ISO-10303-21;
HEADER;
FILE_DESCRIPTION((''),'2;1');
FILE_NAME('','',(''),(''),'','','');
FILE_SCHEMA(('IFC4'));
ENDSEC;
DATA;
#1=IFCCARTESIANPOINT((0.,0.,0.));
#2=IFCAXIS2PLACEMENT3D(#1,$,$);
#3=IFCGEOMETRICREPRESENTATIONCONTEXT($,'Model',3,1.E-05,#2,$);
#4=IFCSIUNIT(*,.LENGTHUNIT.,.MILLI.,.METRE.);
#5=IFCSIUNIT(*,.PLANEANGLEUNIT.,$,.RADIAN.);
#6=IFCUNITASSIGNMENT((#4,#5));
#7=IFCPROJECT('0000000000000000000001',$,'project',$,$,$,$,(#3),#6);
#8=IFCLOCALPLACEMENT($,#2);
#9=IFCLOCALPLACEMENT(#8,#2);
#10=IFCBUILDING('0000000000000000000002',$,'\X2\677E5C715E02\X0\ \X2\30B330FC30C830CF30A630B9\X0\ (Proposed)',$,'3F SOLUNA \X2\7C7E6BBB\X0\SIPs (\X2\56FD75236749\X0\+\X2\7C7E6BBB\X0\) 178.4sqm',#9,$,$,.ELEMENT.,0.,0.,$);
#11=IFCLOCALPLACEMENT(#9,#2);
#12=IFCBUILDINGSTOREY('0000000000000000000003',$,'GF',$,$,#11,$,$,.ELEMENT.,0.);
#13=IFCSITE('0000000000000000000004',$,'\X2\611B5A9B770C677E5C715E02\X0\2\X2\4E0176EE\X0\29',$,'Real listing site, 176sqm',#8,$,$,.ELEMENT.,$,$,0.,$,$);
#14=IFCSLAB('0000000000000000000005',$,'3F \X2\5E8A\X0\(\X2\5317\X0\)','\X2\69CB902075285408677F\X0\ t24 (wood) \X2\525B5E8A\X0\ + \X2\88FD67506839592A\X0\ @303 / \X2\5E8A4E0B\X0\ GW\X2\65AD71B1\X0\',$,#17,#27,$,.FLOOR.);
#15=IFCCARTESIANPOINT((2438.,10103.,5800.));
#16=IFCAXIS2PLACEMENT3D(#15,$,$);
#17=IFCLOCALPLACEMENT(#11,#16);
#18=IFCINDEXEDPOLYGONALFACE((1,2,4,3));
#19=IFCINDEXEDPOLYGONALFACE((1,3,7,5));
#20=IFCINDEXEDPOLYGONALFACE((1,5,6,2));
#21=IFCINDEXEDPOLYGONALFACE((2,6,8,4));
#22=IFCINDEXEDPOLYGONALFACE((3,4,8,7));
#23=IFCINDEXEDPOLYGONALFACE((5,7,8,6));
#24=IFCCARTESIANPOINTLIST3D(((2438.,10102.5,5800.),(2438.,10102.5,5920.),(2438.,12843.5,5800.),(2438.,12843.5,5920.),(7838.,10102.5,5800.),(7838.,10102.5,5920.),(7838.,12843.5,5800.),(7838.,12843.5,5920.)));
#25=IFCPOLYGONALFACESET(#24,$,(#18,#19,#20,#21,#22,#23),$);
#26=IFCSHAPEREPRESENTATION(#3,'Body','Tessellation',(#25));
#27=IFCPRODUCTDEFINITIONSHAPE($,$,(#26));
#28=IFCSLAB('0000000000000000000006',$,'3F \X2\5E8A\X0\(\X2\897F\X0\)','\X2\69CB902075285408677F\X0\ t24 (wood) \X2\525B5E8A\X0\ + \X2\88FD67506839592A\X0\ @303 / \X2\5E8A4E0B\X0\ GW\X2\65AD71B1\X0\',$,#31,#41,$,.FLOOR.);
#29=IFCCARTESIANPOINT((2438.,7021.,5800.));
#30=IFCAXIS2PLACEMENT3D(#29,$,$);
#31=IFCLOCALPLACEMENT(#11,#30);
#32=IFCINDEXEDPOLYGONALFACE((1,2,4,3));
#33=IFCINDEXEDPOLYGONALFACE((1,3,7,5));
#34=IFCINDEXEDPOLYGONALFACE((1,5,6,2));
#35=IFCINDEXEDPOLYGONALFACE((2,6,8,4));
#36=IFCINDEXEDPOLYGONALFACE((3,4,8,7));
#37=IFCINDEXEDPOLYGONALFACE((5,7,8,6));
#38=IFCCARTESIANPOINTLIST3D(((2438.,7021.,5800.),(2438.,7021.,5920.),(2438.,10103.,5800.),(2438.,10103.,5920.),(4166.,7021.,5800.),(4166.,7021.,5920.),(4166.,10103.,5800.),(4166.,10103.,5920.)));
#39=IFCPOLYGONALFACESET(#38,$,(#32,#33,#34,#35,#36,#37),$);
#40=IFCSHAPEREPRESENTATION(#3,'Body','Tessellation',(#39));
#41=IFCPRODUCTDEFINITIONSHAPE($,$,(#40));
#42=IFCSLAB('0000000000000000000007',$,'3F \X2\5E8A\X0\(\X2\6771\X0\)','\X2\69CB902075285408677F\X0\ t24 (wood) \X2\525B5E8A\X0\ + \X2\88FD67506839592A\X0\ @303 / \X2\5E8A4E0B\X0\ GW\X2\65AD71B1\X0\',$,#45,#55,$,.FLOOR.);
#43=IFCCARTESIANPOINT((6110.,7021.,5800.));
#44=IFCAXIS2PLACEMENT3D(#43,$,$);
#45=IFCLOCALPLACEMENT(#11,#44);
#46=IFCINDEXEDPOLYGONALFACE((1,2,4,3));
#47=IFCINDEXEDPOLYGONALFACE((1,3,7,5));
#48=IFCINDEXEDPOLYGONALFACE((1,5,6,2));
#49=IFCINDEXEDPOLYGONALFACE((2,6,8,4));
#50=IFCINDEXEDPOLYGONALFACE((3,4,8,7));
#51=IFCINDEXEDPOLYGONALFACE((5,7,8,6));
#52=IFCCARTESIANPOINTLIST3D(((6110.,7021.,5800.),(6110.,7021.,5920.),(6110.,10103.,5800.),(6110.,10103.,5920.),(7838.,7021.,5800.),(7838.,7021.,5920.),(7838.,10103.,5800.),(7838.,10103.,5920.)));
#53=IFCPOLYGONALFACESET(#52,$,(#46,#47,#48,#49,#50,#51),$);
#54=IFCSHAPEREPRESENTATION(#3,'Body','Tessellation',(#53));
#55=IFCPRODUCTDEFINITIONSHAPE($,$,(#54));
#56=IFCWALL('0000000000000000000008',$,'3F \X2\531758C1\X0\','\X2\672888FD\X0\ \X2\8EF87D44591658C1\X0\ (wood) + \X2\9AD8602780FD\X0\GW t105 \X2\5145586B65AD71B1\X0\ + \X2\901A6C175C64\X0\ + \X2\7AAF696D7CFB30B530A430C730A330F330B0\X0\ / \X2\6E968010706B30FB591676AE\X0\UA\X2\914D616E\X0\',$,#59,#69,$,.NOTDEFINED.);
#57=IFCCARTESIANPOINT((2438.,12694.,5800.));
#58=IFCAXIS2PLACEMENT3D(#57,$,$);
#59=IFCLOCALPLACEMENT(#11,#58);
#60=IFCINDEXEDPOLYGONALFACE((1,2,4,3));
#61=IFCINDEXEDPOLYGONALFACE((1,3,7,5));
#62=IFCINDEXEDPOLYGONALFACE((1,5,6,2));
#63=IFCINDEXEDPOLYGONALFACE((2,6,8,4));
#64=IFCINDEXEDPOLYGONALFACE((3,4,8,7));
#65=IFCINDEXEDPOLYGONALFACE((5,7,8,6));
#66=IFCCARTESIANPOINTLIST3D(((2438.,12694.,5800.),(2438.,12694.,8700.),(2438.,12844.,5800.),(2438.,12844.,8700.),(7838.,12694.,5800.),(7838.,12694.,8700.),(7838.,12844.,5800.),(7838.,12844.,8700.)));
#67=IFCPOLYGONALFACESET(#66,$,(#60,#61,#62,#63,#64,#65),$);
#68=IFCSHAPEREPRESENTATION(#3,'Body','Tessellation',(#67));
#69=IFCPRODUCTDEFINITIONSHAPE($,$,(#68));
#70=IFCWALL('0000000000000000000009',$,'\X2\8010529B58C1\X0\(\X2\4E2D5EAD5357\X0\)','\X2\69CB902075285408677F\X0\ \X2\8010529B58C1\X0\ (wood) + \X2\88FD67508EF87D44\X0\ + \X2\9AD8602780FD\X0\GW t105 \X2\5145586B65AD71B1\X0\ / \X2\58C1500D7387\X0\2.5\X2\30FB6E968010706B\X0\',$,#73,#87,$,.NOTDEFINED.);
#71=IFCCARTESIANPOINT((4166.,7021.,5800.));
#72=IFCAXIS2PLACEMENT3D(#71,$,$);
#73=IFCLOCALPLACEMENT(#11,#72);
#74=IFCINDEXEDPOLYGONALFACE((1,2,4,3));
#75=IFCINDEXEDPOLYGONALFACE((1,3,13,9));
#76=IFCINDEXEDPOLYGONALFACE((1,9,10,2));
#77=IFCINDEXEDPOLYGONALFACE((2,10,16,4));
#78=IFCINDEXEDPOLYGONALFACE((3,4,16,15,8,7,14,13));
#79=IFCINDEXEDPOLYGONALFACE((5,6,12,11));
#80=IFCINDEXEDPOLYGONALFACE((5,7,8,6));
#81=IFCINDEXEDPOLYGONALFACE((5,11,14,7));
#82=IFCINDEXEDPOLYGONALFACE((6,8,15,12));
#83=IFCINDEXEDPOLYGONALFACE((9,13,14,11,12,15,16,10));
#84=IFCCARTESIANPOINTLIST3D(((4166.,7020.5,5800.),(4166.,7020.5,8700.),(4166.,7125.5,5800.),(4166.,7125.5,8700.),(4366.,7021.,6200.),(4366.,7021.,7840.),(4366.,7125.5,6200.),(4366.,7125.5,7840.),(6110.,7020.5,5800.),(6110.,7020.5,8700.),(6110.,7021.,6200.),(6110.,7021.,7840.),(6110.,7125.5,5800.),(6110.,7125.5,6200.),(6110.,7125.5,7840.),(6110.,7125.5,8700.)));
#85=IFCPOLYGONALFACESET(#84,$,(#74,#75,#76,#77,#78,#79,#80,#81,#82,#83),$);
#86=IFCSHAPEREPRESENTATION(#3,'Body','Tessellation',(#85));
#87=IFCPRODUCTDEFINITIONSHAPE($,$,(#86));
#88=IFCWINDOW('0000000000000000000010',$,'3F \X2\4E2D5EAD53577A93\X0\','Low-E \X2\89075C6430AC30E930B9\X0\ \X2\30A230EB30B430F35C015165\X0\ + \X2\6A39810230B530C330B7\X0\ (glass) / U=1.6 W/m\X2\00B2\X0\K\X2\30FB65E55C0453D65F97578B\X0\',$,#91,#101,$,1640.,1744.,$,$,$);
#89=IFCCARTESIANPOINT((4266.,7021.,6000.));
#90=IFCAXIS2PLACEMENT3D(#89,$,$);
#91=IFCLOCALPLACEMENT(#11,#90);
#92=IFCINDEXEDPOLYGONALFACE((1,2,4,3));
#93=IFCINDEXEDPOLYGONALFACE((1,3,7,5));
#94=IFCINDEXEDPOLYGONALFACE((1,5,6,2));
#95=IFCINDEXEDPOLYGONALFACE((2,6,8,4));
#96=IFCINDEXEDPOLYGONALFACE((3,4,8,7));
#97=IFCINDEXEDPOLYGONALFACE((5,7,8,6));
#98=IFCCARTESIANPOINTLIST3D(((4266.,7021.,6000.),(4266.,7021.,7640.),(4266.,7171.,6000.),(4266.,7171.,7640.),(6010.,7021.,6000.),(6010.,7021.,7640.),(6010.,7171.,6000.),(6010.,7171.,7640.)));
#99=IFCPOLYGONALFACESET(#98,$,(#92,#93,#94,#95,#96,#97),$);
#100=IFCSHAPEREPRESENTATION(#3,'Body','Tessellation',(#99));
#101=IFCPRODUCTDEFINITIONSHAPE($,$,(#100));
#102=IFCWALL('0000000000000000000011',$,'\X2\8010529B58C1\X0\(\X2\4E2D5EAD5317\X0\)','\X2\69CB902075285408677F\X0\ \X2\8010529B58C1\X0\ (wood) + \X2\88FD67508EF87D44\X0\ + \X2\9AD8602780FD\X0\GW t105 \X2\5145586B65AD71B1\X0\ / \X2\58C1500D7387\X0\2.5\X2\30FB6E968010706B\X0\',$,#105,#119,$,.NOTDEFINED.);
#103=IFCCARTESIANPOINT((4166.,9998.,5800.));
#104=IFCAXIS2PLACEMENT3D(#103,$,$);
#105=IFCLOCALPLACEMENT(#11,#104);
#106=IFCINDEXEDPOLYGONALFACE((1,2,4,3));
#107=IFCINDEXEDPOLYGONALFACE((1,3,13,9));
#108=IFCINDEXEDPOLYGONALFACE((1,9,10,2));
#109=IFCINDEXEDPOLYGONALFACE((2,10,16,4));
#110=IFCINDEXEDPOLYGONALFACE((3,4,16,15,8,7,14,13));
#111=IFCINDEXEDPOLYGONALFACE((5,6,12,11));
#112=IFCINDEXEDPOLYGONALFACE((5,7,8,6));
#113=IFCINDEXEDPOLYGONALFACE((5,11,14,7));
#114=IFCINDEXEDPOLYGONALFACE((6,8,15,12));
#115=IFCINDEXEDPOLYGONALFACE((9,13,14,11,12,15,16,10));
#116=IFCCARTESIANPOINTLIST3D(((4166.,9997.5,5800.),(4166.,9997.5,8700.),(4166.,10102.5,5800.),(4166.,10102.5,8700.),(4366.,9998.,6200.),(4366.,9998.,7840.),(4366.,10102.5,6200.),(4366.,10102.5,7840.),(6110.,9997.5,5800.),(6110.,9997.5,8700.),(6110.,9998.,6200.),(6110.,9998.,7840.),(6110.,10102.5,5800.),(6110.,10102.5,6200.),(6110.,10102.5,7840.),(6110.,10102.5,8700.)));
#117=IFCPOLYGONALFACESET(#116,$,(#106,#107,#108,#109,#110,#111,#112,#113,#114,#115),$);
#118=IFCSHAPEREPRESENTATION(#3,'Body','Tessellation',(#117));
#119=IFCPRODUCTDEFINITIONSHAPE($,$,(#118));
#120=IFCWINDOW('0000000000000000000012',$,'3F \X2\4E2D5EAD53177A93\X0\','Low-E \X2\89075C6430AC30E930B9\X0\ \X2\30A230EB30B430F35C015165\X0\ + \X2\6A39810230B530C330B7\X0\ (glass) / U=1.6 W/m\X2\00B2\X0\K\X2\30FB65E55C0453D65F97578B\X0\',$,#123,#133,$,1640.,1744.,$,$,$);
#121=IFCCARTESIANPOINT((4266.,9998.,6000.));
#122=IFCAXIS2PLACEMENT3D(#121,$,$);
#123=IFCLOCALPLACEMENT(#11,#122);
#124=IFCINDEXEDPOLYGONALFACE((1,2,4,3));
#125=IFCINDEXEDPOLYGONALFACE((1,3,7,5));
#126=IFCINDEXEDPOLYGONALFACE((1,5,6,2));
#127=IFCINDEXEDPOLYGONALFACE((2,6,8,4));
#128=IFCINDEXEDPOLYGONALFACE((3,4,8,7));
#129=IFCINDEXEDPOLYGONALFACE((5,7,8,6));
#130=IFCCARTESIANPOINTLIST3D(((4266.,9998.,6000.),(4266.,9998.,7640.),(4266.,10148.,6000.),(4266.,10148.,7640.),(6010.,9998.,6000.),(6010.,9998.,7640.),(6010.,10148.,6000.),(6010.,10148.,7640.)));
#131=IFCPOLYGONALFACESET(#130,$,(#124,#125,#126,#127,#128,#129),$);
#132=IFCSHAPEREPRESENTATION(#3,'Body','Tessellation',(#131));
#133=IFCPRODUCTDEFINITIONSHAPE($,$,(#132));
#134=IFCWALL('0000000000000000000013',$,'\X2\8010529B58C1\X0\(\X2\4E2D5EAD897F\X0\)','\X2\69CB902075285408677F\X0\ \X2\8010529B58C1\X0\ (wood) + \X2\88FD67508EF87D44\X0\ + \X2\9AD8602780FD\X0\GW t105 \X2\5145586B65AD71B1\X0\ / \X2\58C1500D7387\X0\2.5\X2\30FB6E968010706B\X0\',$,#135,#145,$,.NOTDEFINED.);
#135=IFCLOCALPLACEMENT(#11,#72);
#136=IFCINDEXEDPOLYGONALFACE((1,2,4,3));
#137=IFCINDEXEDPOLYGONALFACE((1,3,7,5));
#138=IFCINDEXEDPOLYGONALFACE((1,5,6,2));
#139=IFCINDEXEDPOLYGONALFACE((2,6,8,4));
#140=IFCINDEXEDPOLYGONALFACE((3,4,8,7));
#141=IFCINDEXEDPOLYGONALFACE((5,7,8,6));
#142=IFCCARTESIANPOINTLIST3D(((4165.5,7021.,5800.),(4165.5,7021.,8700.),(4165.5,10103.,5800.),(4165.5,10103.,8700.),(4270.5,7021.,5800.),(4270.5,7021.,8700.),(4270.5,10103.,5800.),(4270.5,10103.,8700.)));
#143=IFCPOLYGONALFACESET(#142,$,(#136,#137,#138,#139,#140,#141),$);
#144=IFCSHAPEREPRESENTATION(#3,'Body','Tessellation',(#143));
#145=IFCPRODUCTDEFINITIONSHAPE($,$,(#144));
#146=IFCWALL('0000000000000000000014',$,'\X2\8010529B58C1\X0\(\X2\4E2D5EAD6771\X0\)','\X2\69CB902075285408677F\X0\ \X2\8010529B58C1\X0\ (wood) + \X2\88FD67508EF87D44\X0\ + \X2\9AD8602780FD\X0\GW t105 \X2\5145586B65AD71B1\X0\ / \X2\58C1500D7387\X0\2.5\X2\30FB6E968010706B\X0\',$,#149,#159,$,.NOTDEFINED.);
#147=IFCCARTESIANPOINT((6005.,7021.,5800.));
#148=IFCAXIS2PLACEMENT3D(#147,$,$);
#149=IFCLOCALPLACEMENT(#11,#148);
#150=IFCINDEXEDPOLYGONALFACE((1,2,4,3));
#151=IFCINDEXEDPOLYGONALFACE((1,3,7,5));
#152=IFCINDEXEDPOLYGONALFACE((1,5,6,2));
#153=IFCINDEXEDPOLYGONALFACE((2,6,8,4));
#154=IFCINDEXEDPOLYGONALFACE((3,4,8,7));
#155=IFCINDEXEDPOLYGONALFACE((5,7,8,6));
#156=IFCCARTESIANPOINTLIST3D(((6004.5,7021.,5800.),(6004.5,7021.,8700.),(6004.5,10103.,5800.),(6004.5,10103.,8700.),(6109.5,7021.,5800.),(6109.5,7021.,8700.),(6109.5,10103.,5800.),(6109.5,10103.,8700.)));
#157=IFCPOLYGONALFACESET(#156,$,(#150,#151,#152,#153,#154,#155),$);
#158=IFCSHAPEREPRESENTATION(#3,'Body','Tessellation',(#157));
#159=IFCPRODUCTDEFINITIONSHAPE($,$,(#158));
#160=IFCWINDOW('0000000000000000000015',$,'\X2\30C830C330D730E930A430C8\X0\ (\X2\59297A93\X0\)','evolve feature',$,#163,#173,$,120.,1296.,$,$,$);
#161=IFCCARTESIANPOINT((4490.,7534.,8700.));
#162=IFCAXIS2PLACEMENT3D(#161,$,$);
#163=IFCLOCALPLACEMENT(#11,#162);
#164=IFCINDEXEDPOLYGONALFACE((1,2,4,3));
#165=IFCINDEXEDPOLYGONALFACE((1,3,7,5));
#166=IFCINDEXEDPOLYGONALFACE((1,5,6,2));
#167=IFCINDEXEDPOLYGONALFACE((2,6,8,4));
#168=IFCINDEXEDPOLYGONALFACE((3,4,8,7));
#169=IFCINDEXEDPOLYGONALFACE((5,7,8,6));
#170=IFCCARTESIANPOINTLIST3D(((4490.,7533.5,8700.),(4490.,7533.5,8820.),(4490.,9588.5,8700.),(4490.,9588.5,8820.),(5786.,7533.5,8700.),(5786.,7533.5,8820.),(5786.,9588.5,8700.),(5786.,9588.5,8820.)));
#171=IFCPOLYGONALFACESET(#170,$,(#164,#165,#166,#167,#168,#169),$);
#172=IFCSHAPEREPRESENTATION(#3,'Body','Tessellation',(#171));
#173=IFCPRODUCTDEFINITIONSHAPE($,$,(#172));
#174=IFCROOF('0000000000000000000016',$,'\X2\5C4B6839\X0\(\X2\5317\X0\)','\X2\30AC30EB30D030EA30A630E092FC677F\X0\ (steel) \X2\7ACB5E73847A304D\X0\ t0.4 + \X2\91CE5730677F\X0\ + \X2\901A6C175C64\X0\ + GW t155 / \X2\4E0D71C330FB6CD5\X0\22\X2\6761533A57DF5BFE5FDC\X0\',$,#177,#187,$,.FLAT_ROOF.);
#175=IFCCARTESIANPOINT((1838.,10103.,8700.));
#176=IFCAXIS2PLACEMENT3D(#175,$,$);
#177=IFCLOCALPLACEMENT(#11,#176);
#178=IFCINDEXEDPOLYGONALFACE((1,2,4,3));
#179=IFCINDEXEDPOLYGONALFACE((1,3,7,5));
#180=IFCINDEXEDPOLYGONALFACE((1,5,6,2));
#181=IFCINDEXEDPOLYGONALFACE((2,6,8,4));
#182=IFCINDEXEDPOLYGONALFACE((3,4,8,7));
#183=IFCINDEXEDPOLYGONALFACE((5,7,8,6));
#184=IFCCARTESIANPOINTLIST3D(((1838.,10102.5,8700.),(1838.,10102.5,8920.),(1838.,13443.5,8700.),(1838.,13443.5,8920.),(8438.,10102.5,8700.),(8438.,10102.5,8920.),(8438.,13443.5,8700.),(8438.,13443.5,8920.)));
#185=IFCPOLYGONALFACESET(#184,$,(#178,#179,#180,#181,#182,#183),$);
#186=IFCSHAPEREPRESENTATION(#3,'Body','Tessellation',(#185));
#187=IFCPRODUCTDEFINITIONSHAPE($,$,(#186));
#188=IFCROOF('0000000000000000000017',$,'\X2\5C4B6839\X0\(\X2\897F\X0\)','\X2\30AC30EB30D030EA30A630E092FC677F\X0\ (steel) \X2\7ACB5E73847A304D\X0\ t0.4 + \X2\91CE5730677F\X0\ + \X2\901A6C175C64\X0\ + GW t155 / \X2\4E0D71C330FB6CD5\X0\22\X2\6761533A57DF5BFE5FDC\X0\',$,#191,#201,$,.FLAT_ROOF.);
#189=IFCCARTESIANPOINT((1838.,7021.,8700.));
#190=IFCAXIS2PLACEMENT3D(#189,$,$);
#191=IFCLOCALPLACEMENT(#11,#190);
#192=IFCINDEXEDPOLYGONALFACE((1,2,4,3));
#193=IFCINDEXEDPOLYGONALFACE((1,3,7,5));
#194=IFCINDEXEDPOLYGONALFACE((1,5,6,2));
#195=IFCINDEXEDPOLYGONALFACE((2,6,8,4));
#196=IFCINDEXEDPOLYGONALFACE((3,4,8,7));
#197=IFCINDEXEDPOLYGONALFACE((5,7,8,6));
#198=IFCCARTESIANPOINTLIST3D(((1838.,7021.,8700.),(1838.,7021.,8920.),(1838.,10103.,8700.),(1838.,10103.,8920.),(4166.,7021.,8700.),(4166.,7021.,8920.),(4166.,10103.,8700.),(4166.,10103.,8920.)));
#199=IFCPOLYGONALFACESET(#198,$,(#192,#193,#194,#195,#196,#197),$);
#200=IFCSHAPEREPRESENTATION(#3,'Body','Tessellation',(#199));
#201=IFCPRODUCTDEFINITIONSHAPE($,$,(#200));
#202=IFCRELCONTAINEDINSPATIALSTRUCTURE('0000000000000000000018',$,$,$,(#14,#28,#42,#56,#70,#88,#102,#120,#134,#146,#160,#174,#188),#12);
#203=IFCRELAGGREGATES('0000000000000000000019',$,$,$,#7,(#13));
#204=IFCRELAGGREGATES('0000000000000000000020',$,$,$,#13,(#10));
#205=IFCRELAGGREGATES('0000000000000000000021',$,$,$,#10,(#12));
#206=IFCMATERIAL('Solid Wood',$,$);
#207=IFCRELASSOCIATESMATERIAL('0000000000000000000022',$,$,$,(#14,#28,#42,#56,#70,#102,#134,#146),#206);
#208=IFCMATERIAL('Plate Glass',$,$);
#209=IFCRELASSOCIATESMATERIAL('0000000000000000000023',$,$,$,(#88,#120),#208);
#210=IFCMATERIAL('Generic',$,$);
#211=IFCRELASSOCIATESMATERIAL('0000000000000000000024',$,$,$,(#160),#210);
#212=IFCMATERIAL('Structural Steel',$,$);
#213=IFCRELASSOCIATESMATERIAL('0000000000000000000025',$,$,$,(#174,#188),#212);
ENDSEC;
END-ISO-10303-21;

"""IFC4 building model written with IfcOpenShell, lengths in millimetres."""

from ifc_helpers import new_model, si_unit, frame, frame_2d, origin, place, context, project, spatial, rectangle, extrude, material, element, fill, save


model = new_model("IFC4")

# Units and contexts
model_context = context("Model", 3, precision=1e-05, world=origin())
ifc_project = project(units=[si_unit("LENGTHUNIT", "METRE", prefix="MILLI"), si_unit("PLANEANGLEUNIT", "RADIAN")], contexts=[model_context])

# Site, building, storey
site_placement = place(None, origin())
site = spatial("IfcSite", under=ifc_project, at=site_placement, Name="愛媛県松山市2丁目29", ObjectType="Real listing site, 176sqm", CompositionType="ELEMENT", RefElevation=0.0)
building_placement = place(site_placement, origin())
building = spatial("IfcBuilding", under=site, at=building_placement, Name="松山市 コートハウス (Proposed)", ObjectType="3F SOLUNA 籾殻SIPs (国産杉+籾殻) 178.4sqm", CompositionType="ELEMENT", ElevationOfRefHeight=0.0, ElevationOfTerrain=0.0)
storey_placement = place(building_placement, origin())
storey = spatial("IfcBuildingStorey", under=building, at=storey_placement, Name="GF", CompositionType="ELEMENT", Elevation=0.0)

# Slabs
ifc_material_1 = material(Name="Solid Wood")
slab_1_placement = place(storey_placement, frame((2438.0, 10103.0, 5800.0)))
element("IfcSlab", 1, at=slab_1_placement, inside=storey, material=ifc_material_1, Name="3F 床(北)", Description="構造用合板 t24 (wood) 剛床 + 製材根太 @303 / 床下 GW断熱", PredefinedType="FLOOR", context=model_context, shape_type="SweptSolid", body=[
    extrude(rectangle(XDim=5400.0, YDim=2741.0, at=frame_2d((2700.0, 1370.0))), frame((2438.0, 10103.0, 5800.0)), (0.0, 0.0, 1.0), 120.0),
])
slab_2_placement = place(storey_placement, frame((2438.0, 7021.0, 5800.0)))
element("IfcSlab", 2, at=slab_2_placement, inside=storey, material=ifc_material_1, Name="3F 床(西)", Description="構造用合板 t24 (wood) 剛床 + 製材根太 @303 / 床下 GW断熱", PredefinedType="FLOOR", context=model_context, shape_type="SweptSolid", body=[
    extrude(rectangle(XDim=1728.0, YDim=3082.0, at=frame_2d((864.0, 1541.0))), frame((2438.0, 7021.0, 5800.0)), (0.0, 0.0, 1.0), 120.0),
])
slab_3_placement = place(storey_placement, frame((6110.0, 7021.0, 5800.0)))
element("IfcSlab", 3, at=slab_3_placement, inside=storey, material=ifc_material_1, Name="3F 床(東)", Description="構造用合板 t24 (wood) 剛床 + 製材根太 @303 / 床下 GW断熱", PredefinedType="FLOOR", context=model_context, shape_type="SweptSolid", body=[
    extrude(rectangle(XDim=1728.0, YDim=3082.0, at=frame_2d((864.0, 1541.0))), frame((6110.0, 7021.0, 5800.0)), (0.0, 0.0, 1.0), 120.0),
])

# Wall
wall_1_placement = place(storey_placement, frame((2438.0, 12694.0, 5800.0)))
element("IfcWall", 4, at=wall_1_placement, inside=storey, material=ifc_material_1, Name="3F 北壁", Description="木製 軸組外壁 (wood) + 高性能GW t105 充填断熱 + 通気層 + 窯業系サイディング / 準耐火・外皮UA配慮", PredefinedType="NOTDEFINED", context=model_context, shape_type="SweptSolid", body=[
    extrude(rectangle(XDim=5400.0, YDim=150.0, at=frame_2d((2700.0, 75.0))), frame((2438.0, 12694.0, 5800.0)), (0.0, 0.0, 1.0), 2900.0),
])

# Walls, openings, windows
wall_2_placement = place(storey_placement, frame((4166.0, 7021.0, 5800.0)))
wall_2 = element("IfcWall", 5, at=wall_2_placement, inside=storey, material=ifc_material_1, Name="耐力壁(中庭南)", Description="構造用合板 耐力壁 (wood) + 製材軸組 + 高性能GW t105 充填断熱 / 壁倍率2.5・準耐火", PredefinedType="NOTDEFINED", context=model_context, shape_type="SweptSolid", body=[
    extrude(rectangle(XDim=1944.0, YDim=105.0, at=frame_2d((972.0, 52.0))), frame((4166.0, 7021.0, 5800.0)), (0.0, 0.0, 1.0), 2900.0),
])
opening_1_placement = place(storey_placement, frame((4266.0, 7021.0, 6000.0)))
opening_1 = element("IfcOpeningElement", 6, at=opening_1_placement, cuts=wall_2, PredefinedType="NOTDEFINED", context=model_context, shape_type="SweptSolid", body=[
    extrude(rectangle(XDim=1744.0, YDim=150.0, at=frame_2d((872.0, 75.0))), frame((4266.0, 7021.0, 6000.0)), (0.0, 0.0, 1.0), 1640.0),
])
ifc_material_2 = material(Name="Plate Glass")
window_1_placement = place(storey_placement, frame((4266.0, 7021.0, 6000.0)))
window_1 = element("IfcWindow", 7, at=window_1_placement, inside=storey, material=ifc_material_2, Name="3F 中庭南窓", Description="Low-E 複層ガラス アルゴン封入 + 樹脂サッシ (glass) / U=1.6 W/m²K・日射取得型", OverallHeight=1640.0, OverallWidth=1744.0, context=model_context, shape_type="SweptSolid", body=[
    extrude(rectangle(XDim=1744.0, YDim=150.0, at=frame_2d((872.0, 75.0))), frame((4266.0, 7021.0, 6000.0)), (0.0, 0.0, 1.0), 1640.0),
])
fill(opening_1, window_1)
wall_3_placement = place(storey_placement, frame((4166.0, 9998.0, 5800.0)))
wall_3 = element("IfcWall", 8, at=wall_3_placement, inside=storey, material=ifc_material_1, Name="耐力壁(中庭北)", Description="構造用合板 耐力壁 (wood) + 製材軸組 + 高性能GW t105 充填断熱 / 壁倍率2.5・準耐火", PredefinedType="NOTDEFINED", context=model_context, shape_type="SweptSolid", body=[
    extrude(rectangle(XDim=1944.0, YDim=105.0, at=frame_2d((972.0, 52.0))), frame((4166.0, 9998.0, 5800.0)), (0.0, 0.0, 1.0), 2900.0),
])
opening_2_placement = place(storey_placement, frame((4266.0, 9998.0, 6000.0)))
opening_2 = element("IfcOpeningElement", 9, at=opening_2_placement, cuts=wall_3, PredefinedType="NOTDEFINED", context=model_context, shape_type="SweptSolid", body=[
    extrude(rectangle(XDim=1744.0, YDim=150.0, at=frame_2d((872.0, 75.0))), frame((4266.0, 9998.0, 6000.0)), (0.0, 0.0, 1.0), 1640.0),
])
window_2_placement = place(storey_placement, frame((4266.0, 9998.0, 6000.0)))
window_2 = element("IfcWindow", 10, at=window_2_placement, inside=storey, material=ifc_material_2, Name="3F 中庭北窓", Description="Low-E 複層ガラス アルゴン封入 + 樹脂サッシ (glass) / U=1.6 W/m²K・日射取得型", OverallHeight=1640.0, OverallWidth=1744.0, context=model_context, shape_type="SweptSolid", body=[
    extrude(rectangle(XDim=1744.0, YDim=150.0, at=frame_2d((872.0, 75.0))), frame((4266.0, 9998.0, 6000.0)), (0.0, 0.0, 1.0), 1640.0),
])
fill(opening_2, window_2)

# Walls
wall_4_placement = place(storey_placement, frame((4166.0, 7021.0, 5800.0)))
element("IfcWall", 11, at=wall_4_placement, inside=storey, material=ifc_material_1, Name="耐力壁(中庭西)", Description="構造用合板 耐力壁 (wood) + 製材軸組 + 高性能GW t105 充填断熱 / 壁倍率2.5・準耐火", PredefinedType="NOTDEFINED", context=model_context, shape_type="SweptSolid", body=[
    extrude(rectangle(XDim=105.0, YDim=3082.0, at=frame_2d((52.0, 1541.0))), frame((4166.0, 7021.0, 5800.0)), (0.0, 0.0, 1.0), 2900.0),
])
wall_5_placement = place(storey_placement, frame((6005.0, 7021.0, 5800.0)))
element("IfcWall", 12, at=wall_5_placement, inside=storey, material=ifc_material_1, Name="耐力壁(中庭東)", Description="構造用合板 耐力壁 (wood) + 製材軸組 + 高性能GW t105 充填断熱 / 壁倍率2.5・準耐火", PredefinedType="NOTDEFINED", context=model_context, shape_type="SweptSolid", body=[
    extrude(rectangle(XDim=105.0, YDim=3082.0, at=frame_2d((52.0, 1541.0))), frame((6005.0, 7021.0, 5800.0)), (0.0, 0.0, 1.0), 2900.0),
])

# Window
ifc_material_3 = material(Name="Generic")
window_3_placement = place(storey_placement, frame((4490.0, 7534.0, 8700.0)))
element("IfcWindow", 13, at=window_3_placement, inside=storey, material=ifc_material_3, Name="トップライト (天窓)", Description="evolve feature", OverallHeight=120.0, OverallWidth=1296.0, context=model_context, shape_type="SweptSolid", body=[
    extrude(rectangle(XDim=1296.0, YDim=2055.0, at=frame_2d((648.0, 1027.0))), frame((4490.0, 7534.0, 8700.0)), (0.0, 0.0, 1.0), 120.0),
])

# Roofs
ifc_material_4 = material(Name="Structural Steel")
for number, where, name in (
    (14, (1838.0, 10103.0, 8700.0), "屋根(北)"),
):
    element("IfcRoof", number, at=place(storey_placement, frame(where)), inside=storey, material=ifc_material_4, Name=name, Description="ガルバリウム鋼板 (steel) 立平葺き t0.4 + 野地板 + 通気層 + GW t155 / 不燃・法22条区域対応", PredefinedType="FLAT_ROOF", context=model_context, shape_type="SweptSolid", body=[
        extrude(rectangle(XDim=6600.0, YDim=3341.0, at=frame_2d((3300.0, 1670.0))), frame((1838.0, 10103.0, 8700.0)), (0.0, 0.0, 1.0), 220.0),
    ])
roof_1_placement = place(storey_placement, frame((1838.0, 7021.0, 8700.0)))
element("IfcRoof", 15, at=roof_1_placement, inside=storey, material=ifc_material_4, Name="屋根(西)", Description="ガルバリウム鋼板 (steel) 立平葺き t0.4 + 野地板 + 通気層 + GW t155 / 不燃・法22条区域対応", PredefinedType="FLAT_ROOF", context=model_context, shape_type="SweptSolid", body=[
    extrude(rectangle(XDim=2328.0, YDim=3082.0, at=frame_2d((1164.0, 1541.0))), frame((1838.0, 7021.0, 8700.0)), (0.0, 0.0, 1.0), 220.0),
])

save(model, "model.ifc")
